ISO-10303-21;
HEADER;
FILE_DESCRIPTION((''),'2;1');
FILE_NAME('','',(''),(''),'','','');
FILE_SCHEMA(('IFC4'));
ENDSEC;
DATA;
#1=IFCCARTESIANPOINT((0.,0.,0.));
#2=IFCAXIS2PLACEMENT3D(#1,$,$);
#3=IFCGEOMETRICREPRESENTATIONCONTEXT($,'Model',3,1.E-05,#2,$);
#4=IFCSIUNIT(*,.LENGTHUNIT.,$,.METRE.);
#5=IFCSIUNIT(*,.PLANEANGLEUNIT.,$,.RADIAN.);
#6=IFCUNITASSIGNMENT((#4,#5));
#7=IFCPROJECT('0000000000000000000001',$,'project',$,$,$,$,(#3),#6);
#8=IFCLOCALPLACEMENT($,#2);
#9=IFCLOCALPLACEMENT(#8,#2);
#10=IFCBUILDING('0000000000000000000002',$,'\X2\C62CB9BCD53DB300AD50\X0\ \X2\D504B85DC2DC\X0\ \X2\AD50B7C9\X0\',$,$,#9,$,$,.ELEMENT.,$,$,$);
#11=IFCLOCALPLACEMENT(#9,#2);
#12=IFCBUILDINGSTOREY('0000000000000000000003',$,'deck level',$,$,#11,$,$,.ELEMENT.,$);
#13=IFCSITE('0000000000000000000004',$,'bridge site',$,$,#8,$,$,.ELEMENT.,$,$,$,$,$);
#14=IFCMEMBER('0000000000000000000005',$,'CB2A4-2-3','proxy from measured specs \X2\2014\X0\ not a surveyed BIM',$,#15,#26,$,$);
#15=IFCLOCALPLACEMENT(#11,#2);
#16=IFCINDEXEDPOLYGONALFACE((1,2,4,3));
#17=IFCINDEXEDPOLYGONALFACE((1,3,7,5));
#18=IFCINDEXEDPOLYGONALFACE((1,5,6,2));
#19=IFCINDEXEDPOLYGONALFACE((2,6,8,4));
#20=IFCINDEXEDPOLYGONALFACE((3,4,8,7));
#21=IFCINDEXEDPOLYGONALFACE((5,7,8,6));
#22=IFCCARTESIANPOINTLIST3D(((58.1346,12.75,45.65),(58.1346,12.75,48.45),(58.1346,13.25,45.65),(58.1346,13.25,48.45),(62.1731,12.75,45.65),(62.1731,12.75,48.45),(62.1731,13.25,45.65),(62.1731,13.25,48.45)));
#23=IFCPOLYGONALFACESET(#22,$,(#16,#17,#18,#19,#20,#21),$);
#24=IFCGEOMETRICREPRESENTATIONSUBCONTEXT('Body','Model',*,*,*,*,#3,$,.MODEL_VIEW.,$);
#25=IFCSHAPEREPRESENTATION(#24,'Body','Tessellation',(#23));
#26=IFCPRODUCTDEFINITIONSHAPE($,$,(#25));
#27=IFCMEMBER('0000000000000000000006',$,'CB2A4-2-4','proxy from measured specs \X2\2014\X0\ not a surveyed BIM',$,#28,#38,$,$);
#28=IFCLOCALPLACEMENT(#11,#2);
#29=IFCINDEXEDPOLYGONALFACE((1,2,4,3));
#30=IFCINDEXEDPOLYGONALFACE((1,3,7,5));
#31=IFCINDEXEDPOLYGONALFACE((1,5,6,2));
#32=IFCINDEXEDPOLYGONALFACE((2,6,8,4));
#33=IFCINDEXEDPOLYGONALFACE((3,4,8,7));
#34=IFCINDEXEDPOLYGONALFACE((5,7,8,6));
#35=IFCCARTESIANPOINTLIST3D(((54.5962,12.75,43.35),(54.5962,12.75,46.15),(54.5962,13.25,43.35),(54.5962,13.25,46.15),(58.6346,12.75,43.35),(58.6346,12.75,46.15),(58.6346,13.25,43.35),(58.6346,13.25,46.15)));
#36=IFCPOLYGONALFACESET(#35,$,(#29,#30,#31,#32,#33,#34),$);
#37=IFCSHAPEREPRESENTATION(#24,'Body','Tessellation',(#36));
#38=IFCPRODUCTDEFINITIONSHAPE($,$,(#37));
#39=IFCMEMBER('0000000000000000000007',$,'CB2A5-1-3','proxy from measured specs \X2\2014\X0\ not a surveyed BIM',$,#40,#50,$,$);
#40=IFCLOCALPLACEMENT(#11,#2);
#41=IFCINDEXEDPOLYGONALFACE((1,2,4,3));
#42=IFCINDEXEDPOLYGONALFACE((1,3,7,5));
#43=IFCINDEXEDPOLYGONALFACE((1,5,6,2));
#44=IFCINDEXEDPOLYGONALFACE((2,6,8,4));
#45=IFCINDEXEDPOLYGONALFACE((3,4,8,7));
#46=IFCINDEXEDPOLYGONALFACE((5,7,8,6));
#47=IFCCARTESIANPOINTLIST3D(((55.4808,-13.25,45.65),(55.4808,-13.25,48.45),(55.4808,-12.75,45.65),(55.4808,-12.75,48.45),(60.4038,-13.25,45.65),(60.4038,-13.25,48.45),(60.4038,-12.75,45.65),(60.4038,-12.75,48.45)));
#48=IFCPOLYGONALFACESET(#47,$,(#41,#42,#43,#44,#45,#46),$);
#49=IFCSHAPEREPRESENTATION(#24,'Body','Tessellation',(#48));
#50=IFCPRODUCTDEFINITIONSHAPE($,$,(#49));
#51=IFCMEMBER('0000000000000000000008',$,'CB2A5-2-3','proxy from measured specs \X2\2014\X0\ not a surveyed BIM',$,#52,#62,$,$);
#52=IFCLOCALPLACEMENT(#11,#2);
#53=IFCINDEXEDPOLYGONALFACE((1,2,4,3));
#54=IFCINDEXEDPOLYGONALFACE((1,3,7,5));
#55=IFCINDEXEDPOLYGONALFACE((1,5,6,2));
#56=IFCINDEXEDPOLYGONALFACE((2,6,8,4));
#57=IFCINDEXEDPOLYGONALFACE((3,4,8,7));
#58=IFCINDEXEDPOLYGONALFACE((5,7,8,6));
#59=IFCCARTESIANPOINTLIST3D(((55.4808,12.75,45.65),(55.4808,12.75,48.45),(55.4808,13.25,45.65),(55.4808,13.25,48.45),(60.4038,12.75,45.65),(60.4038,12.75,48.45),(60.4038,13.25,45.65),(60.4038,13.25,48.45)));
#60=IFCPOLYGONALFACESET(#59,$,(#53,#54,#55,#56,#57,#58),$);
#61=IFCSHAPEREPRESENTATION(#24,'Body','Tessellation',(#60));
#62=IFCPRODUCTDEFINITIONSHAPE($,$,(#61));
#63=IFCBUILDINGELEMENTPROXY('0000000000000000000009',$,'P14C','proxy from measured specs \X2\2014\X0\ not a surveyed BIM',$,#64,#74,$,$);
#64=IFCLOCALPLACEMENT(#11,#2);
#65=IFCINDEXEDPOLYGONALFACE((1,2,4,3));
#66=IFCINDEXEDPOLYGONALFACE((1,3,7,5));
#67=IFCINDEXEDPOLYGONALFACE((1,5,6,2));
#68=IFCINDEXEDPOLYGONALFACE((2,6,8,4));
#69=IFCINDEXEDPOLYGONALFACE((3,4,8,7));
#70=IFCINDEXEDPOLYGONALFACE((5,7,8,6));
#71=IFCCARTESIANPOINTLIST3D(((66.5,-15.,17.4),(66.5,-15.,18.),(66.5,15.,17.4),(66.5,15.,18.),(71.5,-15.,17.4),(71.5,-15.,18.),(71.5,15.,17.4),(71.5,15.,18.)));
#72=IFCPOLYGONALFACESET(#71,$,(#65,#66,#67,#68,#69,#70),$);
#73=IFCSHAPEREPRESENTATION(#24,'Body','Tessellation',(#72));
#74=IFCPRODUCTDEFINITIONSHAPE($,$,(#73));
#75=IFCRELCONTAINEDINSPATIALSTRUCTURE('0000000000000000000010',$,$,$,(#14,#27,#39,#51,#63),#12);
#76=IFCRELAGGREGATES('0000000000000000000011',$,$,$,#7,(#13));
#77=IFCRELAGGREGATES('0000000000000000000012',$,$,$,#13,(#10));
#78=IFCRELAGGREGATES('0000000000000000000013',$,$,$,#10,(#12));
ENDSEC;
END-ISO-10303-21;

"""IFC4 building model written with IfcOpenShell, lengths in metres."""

from ifc_helpers import new_model, si_unit, frame, origin, origin_2d, place, context, subcontext, project, spatial, rectangle, extrude, element, save


model = new_model("IFC4")

# Units and contexts
model_context = context("Model", 3, precision=1e-05, world=origin())
body_context = subcontext(model_context, "Body", "Model", "MODEL_VIEW")
ifc_project = project(units=[si_unit("LENGTHUNIT", "METRE"), si_unit("PLANEANGLEUNIT", "RADIAN")], contexts=[model_context])

# Site, building, storey
site_placement = place(None, origin())
site = spatial("IfcSite", under=ifc_project, at=site_placement, Name="bridge site", CompositionType="ELEMENT")
building_placement = place(site_placement, origin())
building = spatial("IfcBuilding", under=site, at=building_placement, Name="올림픽대교 프록시 교량", CompositionType="ELEMENT")
storey_placement = place(building_placement, origin())
storey = spatial("IfcBuildingStorey", under=building, at=storey_placement, Name="deck level", CompositionType="ELEMENT")

# Members
member_1_placement = place(storey_placement, frame((60.1538, 13.0, 45.65)))
element("IfcMember", 1, at=member_1_placement, inside=storey, Name="CB2A4-2-3", Description="proxy from measured specs — not a surveyed BIM", context=body_context, shape_type="SweptSolid", body=[
    extrude(rectangle(XDim=4.0385, YDim=0.5, at=origin_2d()), origin(), (0.0, 0.0, 1.0), 2.8),
])
member_2_placement = place(storey_placement, frame((56.6154, 13.0, 43.35)))
element("IfcMember", 2, at=member_2_placement, inside=storey, Name="CB2A4-2-4", Description="proxy from measured specs — not a surveyed BIM", context=body_context, shape_type="SweptSolid", body=[
    extrude(rectangle(XDim=4.0385, YDim=0.5, at=origin_2d()), origin(), (0.0, 0.0, 1.0), 2.8),
])
for number, where, name in (
    (3, (57.9423, -13.0, 45.65), "CB2A5-1-3"),
    (4, (57.9423, 13.0, 45.65), "CB2A5-2-3"),
):
    element("IfcMember", number, at=place(storey_placement, frame(where)), inside=storey, Name=name, Description="proxy from measured specs — not a surveyed BIM", context=body_context, shape_type="SweptSolid", body=[
        extrude(rectangle(XDim=4.9231, YDim=0.5, at=origin_2d()), origin(), (0.0, 0.0, 1.0), 2.8),
    ])

# Building element proxy
proxy_placement = place(storey_placement, frame((69.0, 0.0, 17.4)))
element("IfcBuildingElementProxy", 5, at=proxy_placement, inside=storey, Name="P14C", Description="proxy from measured specs — not a surveyed BIM", context=body_context, shape_type="SweptSolid", body=[
    extrude(rectangle(XDim=5.0, YDim=30.0, at=origin_2d()), origin(), (0.0, 0.0, 1.0), 0.6),
])

save(model, "model.ifc")
